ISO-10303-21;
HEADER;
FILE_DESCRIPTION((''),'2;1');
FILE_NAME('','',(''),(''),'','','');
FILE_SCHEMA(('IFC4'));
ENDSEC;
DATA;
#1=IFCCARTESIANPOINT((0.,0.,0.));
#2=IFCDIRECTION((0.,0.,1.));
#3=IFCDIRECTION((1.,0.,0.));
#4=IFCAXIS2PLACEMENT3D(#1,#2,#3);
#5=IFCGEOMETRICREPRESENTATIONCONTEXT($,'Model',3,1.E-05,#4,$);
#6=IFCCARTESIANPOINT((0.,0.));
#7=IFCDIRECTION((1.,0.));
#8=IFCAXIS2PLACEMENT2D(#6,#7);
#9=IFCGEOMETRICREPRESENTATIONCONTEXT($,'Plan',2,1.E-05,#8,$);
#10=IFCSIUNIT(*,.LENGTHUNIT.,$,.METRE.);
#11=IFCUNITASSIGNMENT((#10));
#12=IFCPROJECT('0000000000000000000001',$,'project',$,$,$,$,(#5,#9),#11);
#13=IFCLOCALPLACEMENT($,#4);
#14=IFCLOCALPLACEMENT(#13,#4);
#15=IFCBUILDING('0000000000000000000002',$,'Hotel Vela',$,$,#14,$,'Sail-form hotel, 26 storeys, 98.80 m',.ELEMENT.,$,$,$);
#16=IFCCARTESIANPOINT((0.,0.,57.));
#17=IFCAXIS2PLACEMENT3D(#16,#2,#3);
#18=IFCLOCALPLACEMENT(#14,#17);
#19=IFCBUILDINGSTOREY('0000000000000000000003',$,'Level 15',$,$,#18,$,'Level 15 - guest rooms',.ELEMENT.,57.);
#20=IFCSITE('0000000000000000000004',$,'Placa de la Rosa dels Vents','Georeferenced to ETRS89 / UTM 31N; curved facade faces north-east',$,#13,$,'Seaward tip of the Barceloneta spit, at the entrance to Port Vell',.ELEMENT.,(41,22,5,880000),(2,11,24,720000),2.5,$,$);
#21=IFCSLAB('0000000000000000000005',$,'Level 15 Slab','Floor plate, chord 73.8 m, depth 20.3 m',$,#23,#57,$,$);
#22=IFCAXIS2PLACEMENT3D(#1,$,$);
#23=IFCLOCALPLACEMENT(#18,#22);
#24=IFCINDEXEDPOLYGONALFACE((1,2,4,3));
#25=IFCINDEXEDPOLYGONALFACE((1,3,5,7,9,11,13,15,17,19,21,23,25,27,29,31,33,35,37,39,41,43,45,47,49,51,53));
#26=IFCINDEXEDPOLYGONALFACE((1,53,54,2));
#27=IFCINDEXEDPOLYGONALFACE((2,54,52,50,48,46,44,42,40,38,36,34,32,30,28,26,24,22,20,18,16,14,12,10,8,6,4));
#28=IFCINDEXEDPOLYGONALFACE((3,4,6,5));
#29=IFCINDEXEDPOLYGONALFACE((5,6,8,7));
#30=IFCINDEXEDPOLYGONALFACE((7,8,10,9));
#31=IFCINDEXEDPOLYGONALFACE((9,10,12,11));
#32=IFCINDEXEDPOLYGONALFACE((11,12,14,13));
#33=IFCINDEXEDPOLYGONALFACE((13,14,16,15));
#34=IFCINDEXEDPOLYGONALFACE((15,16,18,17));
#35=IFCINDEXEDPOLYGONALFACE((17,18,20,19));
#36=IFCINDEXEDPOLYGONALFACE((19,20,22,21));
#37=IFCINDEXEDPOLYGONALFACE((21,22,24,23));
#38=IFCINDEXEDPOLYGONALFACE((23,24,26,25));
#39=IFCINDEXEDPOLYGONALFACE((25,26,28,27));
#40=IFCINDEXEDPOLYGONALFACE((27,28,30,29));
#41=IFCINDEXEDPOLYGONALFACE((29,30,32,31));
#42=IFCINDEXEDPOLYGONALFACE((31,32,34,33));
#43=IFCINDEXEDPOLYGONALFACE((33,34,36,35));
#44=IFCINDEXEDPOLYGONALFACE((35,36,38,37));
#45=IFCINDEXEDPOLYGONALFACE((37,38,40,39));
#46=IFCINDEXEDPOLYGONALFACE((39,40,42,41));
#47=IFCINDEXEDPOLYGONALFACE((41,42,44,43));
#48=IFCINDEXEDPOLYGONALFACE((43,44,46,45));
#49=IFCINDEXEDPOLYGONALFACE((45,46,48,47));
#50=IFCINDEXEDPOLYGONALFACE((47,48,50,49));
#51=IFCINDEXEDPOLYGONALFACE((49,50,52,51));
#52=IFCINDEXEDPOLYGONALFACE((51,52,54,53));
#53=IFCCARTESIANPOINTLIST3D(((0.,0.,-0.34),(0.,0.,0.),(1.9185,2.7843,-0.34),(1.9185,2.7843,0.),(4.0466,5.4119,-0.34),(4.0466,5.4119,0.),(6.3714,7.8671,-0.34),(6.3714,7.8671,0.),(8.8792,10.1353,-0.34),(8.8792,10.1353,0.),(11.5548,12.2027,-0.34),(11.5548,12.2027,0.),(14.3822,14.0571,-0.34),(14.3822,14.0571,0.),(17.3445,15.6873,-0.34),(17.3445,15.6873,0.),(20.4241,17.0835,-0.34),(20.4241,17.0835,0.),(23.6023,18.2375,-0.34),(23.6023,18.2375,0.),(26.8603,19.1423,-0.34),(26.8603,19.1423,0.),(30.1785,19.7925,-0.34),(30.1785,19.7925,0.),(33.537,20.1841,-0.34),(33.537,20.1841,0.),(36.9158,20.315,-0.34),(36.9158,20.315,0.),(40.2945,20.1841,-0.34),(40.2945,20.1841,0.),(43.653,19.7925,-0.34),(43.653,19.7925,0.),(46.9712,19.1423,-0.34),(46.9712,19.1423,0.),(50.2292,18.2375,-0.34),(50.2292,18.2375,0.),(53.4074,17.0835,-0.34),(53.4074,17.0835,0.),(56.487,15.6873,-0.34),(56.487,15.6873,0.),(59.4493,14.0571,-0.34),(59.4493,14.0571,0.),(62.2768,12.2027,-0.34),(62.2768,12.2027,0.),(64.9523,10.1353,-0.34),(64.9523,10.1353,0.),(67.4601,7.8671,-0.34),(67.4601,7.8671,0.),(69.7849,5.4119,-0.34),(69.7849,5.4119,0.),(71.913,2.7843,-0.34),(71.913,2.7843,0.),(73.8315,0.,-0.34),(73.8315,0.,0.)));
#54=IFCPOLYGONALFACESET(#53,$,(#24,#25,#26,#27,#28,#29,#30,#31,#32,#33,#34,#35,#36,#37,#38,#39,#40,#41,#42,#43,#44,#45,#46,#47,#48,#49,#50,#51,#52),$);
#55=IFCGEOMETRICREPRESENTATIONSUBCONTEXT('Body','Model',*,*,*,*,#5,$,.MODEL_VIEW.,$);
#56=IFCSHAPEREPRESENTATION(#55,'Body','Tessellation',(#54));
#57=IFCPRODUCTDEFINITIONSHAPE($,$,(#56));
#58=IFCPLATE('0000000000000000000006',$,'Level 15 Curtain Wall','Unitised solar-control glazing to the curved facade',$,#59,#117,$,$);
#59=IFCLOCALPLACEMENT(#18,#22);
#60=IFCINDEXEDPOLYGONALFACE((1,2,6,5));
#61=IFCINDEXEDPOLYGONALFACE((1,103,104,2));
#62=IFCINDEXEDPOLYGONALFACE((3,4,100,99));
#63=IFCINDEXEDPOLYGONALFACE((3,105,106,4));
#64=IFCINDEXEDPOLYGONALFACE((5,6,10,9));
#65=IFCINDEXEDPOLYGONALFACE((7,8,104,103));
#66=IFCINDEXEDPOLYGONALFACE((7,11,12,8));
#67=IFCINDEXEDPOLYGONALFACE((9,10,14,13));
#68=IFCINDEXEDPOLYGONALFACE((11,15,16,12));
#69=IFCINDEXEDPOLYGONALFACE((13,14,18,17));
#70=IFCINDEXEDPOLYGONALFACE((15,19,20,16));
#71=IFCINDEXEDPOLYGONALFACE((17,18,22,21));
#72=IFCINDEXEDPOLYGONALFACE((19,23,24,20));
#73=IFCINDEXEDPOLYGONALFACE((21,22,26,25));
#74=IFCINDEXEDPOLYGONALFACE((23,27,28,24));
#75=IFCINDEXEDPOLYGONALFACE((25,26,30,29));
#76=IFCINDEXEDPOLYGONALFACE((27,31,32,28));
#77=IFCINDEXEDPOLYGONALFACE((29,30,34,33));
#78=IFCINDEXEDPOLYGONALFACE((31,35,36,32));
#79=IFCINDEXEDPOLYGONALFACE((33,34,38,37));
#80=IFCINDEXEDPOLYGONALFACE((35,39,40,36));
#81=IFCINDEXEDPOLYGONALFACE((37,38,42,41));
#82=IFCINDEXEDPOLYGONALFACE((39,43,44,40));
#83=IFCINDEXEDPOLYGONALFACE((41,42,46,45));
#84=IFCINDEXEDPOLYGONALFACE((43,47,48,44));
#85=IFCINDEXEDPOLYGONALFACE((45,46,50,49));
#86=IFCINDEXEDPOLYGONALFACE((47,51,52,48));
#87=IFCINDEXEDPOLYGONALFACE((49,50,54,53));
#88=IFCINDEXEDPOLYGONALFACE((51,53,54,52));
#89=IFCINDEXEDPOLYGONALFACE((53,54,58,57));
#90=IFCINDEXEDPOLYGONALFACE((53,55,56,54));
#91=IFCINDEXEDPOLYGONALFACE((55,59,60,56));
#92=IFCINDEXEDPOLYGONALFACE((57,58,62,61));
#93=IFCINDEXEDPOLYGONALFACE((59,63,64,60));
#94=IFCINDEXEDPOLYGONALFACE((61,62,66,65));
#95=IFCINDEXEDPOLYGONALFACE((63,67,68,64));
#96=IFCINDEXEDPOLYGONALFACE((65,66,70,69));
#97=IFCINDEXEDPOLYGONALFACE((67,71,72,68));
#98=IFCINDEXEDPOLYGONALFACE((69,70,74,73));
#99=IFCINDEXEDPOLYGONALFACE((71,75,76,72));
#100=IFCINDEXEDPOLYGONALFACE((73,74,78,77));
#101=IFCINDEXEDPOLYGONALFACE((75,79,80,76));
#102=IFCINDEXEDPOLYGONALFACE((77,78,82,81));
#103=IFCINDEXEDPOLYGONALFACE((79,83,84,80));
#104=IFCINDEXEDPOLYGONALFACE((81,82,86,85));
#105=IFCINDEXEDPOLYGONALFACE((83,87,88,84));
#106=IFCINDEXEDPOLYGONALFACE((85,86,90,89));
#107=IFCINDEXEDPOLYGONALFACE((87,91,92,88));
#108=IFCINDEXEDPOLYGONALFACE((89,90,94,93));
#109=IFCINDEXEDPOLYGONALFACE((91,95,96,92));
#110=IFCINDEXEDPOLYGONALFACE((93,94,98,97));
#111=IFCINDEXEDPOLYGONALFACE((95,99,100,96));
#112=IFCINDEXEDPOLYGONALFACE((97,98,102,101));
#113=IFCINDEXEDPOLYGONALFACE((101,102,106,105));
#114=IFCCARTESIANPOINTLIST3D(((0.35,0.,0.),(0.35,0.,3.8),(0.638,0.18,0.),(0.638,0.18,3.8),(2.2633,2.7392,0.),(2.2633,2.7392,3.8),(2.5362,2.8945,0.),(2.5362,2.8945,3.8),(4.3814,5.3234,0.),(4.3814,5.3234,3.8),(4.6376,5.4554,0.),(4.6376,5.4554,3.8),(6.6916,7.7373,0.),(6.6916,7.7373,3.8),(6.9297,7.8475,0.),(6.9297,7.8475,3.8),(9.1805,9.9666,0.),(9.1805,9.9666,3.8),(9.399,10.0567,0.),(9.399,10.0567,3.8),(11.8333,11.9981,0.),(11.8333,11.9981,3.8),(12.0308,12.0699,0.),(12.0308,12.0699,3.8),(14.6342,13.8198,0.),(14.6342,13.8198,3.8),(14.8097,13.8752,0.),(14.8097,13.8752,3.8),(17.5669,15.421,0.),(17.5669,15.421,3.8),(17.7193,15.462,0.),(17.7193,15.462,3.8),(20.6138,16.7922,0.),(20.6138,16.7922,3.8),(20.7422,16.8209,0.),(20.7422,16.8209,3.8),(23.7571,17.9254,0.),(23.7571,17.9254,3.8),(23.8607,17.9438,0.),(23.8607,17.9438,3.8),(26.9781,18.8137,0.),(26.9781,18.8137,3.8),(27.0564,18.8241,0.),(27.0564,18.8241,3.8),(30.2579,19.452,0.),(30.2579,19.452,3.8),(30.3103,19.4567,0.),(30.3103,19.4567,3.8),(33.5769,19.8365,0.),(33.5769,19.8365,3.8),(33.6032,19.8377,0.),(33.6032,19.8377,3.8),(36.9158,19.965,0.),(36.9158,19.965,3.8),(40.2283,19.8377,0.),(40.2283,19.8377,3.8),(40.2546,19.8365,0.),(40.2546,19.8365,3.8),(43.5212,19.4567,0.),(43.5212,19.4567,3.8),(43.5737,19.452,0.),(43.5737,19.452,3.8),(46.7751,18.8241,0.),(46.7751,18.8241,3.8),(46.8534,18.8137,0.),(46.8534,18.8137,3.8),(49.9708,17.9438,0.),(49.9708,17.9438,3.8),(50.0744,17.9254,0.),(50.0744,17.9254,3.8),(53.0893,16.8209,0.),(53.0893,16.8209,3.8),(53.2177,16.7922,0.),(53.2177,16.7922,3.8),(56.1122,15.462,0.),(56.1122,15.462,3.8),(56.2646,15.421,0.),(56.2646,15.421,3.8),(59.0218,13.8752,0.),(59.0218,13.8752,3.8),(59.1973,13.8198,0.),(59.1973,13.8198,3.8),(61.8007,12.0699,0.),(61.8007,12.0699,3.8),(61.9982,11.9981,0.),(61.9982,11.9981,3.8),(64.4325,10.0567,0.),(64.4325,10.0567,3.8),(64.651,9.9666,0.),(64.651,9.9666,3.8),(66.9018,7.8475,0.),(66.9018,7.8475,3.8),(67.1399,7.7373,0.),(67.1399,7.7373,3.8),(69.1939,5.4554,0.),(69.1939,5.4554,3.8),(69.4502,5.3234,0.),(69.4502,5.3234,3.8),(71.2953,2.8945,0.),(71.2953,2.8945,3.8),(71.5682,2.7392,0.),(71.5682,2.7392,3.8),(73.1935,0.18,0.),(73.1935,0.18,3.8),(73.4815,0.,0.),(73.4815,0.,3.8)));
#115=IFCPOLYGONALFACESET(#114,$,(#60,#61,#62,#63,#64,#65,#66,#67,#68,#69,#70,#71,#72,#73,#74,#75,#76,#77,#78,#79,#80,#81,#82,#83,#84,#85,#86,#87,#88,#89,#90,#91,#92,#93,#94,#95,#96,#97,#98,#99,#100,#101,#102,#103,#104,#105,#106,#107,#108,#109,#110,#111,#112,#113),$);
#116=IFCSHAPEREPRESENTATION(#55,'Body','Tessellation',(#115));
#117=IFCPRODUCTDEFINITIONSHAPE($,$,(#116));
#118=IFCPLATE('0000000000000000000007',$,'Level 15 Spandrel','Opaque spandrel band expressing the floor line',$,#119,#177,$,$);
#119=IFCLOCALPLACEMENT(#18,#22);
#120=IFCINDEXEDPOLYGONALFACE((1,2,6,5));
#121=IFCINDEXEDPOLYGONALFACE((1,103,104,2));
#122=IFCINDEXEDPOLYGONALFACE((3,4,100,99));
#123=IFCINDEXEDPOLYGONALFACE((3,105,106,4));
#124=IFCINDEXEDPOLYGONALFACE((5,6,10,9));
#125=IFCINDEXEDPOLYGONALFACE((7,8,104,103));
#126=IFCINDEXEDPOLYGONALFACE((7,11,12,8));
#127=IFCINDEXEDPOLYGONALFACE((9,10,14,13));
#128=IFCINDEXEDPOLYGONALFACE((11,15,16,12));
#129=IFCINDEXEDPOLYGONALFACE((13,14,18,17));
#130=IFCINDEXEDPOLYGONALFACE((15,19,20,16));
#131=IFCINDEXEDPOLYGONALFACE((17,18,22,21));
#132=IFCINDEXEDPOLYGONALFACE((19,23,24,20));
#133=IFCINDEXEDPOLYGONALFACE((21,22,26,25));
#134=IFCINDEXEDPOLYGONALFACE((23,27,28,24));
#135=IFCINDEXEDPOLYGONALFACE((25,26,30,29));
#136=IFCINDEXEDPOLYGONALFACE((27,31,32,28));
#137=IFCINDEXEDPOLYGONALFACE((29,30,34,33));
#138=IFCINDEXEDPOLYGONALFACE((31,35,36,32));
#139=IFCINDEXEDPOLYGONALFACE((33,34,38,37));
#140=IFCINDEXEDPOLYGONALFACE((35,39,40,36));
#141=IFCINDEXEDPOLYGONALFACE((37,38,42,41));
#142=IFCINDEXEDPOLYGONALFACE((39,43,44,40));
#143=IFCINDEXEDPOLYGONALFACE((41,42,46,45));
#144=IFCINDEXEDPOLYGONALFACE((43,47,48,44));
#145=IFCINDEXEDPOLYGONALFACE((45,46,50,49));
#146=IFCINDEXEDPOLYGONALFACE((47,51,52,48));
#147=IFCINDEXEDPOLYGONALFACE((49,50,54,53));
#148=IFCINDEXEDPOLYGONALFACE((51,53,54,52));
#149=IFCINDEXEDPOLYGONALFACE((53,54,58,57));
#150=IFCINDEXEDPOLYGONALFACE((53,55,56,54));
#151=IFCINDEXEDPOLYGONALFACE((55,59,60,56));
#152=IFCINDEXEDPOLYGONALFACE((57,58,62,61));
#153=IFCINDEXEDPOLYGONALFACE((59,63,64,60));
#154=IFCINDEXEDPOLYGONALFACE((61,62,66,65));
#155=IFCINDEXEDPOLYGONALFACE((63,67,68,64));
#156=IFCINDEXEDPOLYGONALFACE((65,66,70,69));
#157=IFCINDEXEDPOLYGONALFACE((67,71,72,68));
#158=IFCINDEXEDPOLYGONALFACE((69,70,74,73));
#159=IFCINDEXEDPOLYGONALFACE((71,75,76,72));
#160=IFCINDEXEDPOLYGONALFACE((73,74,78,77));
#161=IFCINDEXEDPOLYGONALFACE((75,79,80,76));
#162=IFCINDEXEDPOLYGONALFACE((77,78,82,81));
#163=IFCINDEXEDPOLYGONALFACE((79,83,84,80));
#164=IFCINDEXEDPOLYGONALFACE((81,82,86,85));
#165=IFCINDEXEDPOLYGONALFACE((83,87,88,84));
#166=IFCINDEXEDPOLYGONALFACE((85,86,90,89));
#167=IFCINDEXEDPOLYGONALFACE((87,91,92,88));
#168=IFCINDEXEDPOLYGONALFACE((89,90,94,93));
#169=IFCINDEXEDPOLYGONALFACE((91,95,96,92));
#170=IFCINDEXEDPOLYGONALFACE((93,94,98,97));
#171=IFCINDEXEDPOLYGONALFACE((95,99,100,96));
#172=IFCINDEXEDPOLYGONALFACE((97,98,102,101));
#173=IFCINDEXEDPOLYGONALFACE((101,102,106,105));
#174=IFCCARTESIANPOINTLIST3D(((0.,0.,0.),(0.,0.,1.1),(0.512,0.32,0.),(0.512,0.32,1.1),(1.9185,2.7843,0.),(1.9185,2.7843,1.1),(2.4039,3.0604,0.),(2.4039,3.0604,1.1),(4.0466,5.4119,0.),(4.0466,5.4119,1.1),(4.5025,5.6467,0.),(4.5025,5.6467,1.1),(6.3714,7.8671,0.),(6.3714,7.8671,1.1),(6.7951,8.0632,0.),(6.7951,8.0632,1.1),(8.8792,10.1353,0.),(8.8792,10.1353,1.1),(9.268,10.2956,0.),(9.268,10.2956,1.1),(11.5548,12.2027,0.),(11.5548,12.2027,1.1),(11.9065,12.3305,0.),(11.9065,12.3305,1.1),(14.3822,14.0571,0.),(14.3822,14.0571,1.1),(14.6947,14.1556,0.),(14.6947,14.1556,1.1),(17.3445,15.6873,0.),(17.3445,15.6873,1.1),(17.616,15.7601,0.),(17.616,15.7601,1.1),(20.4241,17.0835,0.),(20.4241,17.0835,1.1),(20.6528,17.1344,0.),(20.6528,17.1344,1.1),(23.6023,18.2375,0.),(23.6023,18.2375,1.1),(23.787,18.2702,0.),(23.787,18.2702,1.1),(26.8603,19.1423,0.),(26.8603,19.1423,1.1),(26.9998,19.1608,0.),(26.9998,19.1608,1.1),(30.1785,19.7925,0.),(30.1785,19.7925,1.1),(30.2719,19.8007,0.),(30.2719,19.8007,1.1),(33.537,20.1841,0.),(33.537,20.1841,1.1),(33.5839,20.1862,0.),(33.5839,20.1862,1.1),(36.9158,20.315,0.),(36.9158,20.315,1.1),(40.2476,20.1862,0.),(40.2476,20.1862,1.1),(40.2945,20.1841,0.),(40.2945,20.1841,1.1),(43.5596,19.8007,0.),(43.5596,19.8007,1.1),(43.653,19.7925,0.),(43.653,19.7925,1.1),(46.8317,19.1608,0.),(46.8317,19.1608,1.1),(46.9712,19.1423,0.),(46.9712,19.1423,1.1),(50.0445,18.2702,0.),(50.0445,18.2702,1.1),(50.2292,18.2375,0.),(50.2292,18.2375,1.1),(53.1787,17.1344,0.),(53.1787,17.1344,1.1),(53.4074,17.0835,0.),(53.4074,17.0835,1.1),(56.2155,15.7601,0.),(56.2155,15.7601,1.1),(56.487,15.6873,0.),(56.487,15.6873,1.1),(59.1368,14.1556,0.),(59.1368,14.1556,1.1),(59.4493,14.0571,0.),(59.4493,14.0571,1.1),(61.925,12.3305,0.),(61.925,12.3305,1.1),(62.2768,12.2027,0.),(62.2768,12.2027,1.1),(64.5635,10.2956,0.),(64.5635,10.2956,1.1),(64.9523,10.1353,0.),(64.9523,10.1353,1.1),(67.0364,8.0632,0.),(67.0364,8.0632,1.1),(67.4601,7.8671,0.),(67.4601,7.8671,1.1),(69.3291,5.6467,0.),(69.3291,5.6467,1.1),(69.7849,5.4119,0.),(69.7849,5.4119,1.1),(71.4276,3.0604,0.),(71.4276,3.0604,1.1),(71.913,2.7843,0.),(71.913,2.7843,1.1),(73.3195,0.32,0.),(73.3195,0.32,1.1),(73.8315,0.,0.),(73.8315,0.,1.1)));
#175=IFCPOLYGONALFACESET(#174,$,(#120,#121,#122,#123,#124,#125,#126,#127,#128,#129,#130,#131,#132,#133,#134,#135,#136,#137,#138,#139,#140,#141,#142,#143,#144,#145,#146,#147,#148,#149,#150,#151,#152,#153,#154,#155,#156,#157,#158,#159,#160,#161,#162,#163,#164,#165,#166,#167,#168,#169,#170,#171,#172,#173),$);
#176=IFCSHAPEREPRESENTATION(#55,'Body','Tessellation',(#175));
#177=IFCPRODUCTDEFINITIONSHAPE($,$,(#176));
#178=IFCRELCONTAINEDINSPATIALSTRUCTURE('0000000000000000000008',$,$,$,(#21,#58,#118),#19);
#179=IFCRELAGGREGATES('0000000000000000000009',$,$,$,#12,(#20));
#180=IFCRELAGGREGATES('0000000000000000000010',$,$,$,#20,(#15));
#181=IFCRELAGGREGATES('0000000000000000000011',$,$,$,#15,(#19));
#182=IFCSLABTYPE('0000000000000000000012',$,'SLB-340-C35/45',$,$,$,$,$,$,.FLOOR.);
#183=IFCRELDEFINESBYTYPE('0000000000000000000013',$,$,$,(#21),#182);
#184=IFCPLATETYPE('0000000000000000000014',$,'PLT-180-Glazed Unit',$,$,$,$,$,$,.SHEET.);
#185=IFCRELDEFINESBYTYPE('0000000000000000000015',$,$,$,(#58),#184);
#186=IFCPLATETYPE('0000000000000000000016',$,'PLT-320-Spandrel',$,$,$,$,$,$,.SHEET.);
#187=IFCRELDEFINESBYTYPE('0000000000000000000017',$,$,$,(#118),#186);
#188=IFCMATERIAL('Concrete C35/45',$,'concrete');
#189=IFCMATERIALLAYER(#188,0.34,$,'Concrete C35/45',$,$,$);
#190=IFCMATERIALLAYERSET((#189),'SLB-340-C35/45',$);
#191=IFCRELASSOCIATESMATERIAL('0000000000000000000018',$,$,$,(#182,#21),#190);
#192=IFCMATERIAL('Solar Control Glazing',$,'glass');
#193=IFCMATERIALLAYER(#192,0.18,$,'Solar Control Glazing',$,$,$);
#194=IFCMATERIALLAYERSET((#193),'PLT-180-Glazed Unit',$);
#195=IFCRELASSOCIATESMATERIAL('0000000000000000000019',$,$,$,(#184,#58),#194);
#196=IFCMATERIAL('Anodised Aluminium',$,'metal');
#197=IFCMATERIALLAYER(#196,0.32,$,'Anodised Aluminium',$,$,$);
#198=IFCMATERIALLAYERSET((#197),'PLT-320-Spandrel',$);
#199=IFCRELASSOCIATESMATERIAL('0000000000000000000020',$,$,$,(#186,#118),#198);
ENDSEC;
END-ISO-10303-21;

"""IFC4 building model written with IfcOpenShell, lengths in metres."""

from ifc_helpers import new_model, si_unit, frame, origin_with_axes, origin_2d_with_axis, place, context, subcontext, project, spatial, line, indexed_curve, outline, extrude, material, layer, layer_set, layer_usage, type_object, element, save


model = new_model("IFC4")

# Units and contexts
model_context = context("Model", 3, precision=1e-05, world=origin_with_axes())
plan_context = context("Plan", 2, precision=1e-05, world=origin_2d_with_axis())
body_context = subcontext(model_context, "Body", "Model", "MODEL_VIEW")
ifc_project = project(units=[si_unit("LENGTHUNIT", "METRE")], contexts=[model_context, plan_context])

# Site, building, storey
site_placement = place(None, origin_with_axes())
site = spatial("IfcSite", under=ifc_project, at=site_placement, Name="Placa de la Rosa dels Vents", Description="Georeferenced to ETRS89 / UTM 31N; curved facade faces north-east", LongName="Seaward tip of the Barceloneta spit, at the entrance to Port Vell", CompositionType="ELEMENT", RefLatitude=(41, 22, 5, 880000), RefLongitude=(2, 11, 24, 720000), RefElevation=2.5)
building_placement = place(site_placement, origin_with_axes())
building = spatial("IfcBuilding", under=site, at=building_placement, Name="Hotel Vela", LongName="Sail-form hotel, 26 storeys, 98.80 m", CompositionType="ELEMENT")
storey_placement = place(building_placement, frame((0.0, 0.0, 57.0), z_axis=(0.0, 0.0, 1.0), x_axis=(1.0, 0.0, 0.0)))
storey = spatial("IfcBuildingStorey", under=building, at=storey_placement, Name="Level 15", LongName="Level 15 - guest rooms", CompositionType="ELEMENT", Elevation=57.0)

# Slab
ifc_material_1 = material(Name="Concrete C35/45", Category="concrete")
ifc_layer_1 = layer(ifc_material_1, 0.34, Name="Concrete C35/45")
ifc_layer_set_1 = layer_set([ifc_layer_1], Name="SLB-340-C35/45")
ifc_layer_usage_1 = layer_usage(ifc_layer_set_1, "AXIS3", "POSITIVE", 0.0)
slab_type = type_object("IfcSlabType", Name="SLB-340-C35/45", PredefinedType="FLOOR", material=ifc_layer_set_1)
slab_placement = place(storey_placement, frame((0.0, 0.0, -0.34), z_axis=(0.0, 0.0, 1.0), x_axis=(1.0, 0.0, 0.0)))
element("IfcSlab", 1, at=slab_placement, inside=storey, type_object=slab_type, material=ifc_layer_usage_1, Name="Level 15 Slab", Description="Floor plate, chord 73.8 m, depth 20.3 m", context=body_context, shape_type="SweptSolid", body=[
    extrude(outline(indexed_curve([(0.0, 0.0), (73.8315, 0.0), (71.913, 2.7843), (69.7849, 5.4119), (67.4601, 7.8671), (64.9523, 10.1353), (62.2768, 12.2027), (59.4493, 14.0571), (56.487, 15.6873), (53.4074, 17.0835), (50.2292, 18.2375), (46.9712, 19.1423), (43.653, 19.7925), (40.2945, 20.1841), (36.9158, 20.315), (33.537, 20.1841), (30.1785, 19.7925), (26.8603, 19.1423), (23.6023, 18.2375), (20.4241, 17.0835), (17.3445, 15.6873), (14.3822, 14.0571), (11.5548, 12.2027), (8.8792, 10.1353), (6.3714, 7.8671), (4.0466, 5.4119), (1.9185, 2.7843)], segments=[line(1, 2, 3, 4, 5, 6, 7, 8, 9, 10, 11, 12, 13, 14, 15, 16, 17, 18, 19, 20, 21, 22, 23, 24, 25, 26, 27, 1)])), origin_with_axes(), (0.0, 0.0, 1.0), 0.34),
])

# Plates
ifc_material_2 = material(Name="Solar Control Glazing", Category="glass")
ifc_layer_2 = layer(ifc_material_2, 0.18, Name="Solar Control Glazing")
ifc_layer_set_2 = layer_set([ifc_layer_2], Name="PLT-180-Glazed Unit")
ifc_layer_usage_2 = layer_usage(ifc_layer_set_2, "AXIS2", "POSITIVE", 0.0)
plate_type_1 = type_object("IfcPlateType", Name="PLT-180-Glazed Unit", PredefinedType="SHEET", material=ifc_layer_set_2)
plate_1_placement = place(storey_placement, frame((0.35, 0.0, 0.0), z_axis=(0.0, 0.0, 1.0), x_axis=(1.0, 0.0, 0.0)))
element("IfcPlate", 2, at=plate_1_placement, inside=storey, type_object=plate_type_1, material=ifc_layer_usage_2, Name="Level 15 Curtain Wall", Description="Unitised solar-control glazing to the curved facade", context=body_context, shape_type="SweptSolid", body=[
    extrude(outline(indexed_curve([(73.1315, 0.0), (71.2182, 2.7392), (69.1002, 5.3234), (66.7899, 7.7373), (64.301, 9.9666), (61.6482, 11.9981), (58.8473, 13.8198), (55.9146, 15.421), (52.8677, 16.7922), (49.7244, 17.9254), (46.5034, 18.8137), (43.2237, 19.452), (39.9046, 19.8365), (36.5658, 19.965), (33.2269, 19.8365), (29.9079, 19.452), (26.6281, 18.8137), (23.4071, 17.9254), (20.2638, 16.7922), (17.2169, 15.421), (14.2842, 13.8198), (11.4833, 11.9981), (8.8305, 9.9666), (6.3416, 7.7373), (4.0314, 5.3234), (1.9133, 2.7392), (0.0, 0.0), (72.8435, 0.18), (2.1862, 2.8945), (4.2876, 5.4554), (6.5797, 7.8475), (9.049, 10.0567), (11.6808, 12.0699), (14.4597, 13.8752), (17.3693, 15.462), (20.3922, 16.8209), (23.5107, 17.9438), (26.7064, 18.8241), (29.9603, 19.4567), (33.2532, 19.8377), (36.5658, 19.965), (39.8783, 19.8377), (43.1712, 19.4567), (46.4251, 18.8241), (49.6208, 17.9438), (52.7393, 16.8209), (55.7622, 15.462), (58.6718, 13.8752), (61.4507, 12.0699), (64.0825, 10.0567), (66.5518, 7.8475), (68.8439, 5.4554), (70.9453, 2.8945), (0.288, 0.18)], segments=[line(1, 2, 3, 4, 5, 6, 7, 8, 9, 10, 11, 12, 13, 14, 15, 16, 17, 18, 19, 20, 21, 22, 23, 24, 25, 26, 27, 28, 29, 30, 31, 32, 33, 34, 35, 36, 37, 38, 39, 40, 41, 42, 43, 44, 45, 46, 47, 48, 49, 50, 51, 52, 53, 54, 1)])), origin_with_axes(), (0.0, 0.0, 1.0), 3.8),
])
ifc_material_3 = material(Name="Anodised Aluminium", Category="metal")
ifc_layer_3 = layer(ifc_material_3, 0.32, Name="Anodised Aluminium")
ifc_layer_set_3 = layer_set([ifc_layer_3], Name="PLT-320-Spandrel")
ifc_layer_usage_3 = layer_usage(ifc_layer_set_3, "AXIS2", "POSITIVE", 0.0)
plate_type_2 = type_object("IfcPlateType", Name="PLT-320-Spandrel", PredefinedType="SHEET", material=ifc_layer_set_3)
plate_2_placement = place(storey_placement, origin_with_axes())
element("IfcPlate", 3, at=plate_2_placement, inside=storey, type_object=plate_type_2, material=ifc_layer_usage_3, Name="Level 15 Spandrel", Description="Opaque spandrel band expressing the floor line", context=body_context, shape_type="SweptSolid", body=[
    extrude(outline(indexed_curve([(73.8315, 0.0), (71.913, 2.7843), (69.7849, 5.4119), (67.4601, 7.8671), (64.9523, 10.1353), (62.2768, 12.2027), (59.4493, 14.0571), (56.487, 15.6873), (53.4074, 17.0835), (50.2292, 18.2375), (46.9712, 19.1423), (43.653, 19.7925), (40.2945, 20.1841), (36.9158, 20.315), (33.537, 20.1841), (30.1785, 19.7925), (26.8603, 19.1423), (23.6023, 18.2375), (20.4241, 17.0835), (17.3445, 15.6873), (14.3822, 14.0571), (11.5548, 12.2027), (8.8792, 10.1353), (6.3714, 7.8671), (4.0466, 5.4119), (1.9185, 2.7843), (0.0, 0.0), (73.3195, 0.32), (2.4039, 3.0604), (4.5025, 5.6467), (6.7951, 8.0632), (9.268, 10.2956), (11.9065, 12.3305), (14.6947, 14.1556), (17.616, 15.7601), (20.6528, 17.1344), (23.787, 18.2702), (26.9998, 19.1608), (30.2719, 19.8007), (33.5839, 20.1862), (36.9158, 20.315), (40.2476, 20.1862), (43.5596, 19.8007), (46.8317, 19.1608), (50.0445, 18.2702), (53.1787, 17.1344), (56.2155, 15.7601), (59.1368, 14.1556), (61.925, 12.3305), (64.5635, 10.2956), (67.0364, 8.0632), (69.3291, 5.6467), (71.4276, 3.0604), (0.512, 0.32)], segments=[line(1, 2, 3, 4, 5, 6, 7, 8, 9, 10, 11, 12, 13, 14, 15, 16, 17, 18, 19, 20, 21, 22, 23, 24, 25, 26, 27, 28, 29, 30, 31, 32, 33, 34, 35, 36, 37, 38, 39, 40, 41, 42, 43, 44, 45, 46, 47, 48, 49, 50, 51, 52, 53, 54, 1)])), origin_with_axes(), (0.0, 0.0, 1.0), 1.1),
])

save(model, "model.ifc")
